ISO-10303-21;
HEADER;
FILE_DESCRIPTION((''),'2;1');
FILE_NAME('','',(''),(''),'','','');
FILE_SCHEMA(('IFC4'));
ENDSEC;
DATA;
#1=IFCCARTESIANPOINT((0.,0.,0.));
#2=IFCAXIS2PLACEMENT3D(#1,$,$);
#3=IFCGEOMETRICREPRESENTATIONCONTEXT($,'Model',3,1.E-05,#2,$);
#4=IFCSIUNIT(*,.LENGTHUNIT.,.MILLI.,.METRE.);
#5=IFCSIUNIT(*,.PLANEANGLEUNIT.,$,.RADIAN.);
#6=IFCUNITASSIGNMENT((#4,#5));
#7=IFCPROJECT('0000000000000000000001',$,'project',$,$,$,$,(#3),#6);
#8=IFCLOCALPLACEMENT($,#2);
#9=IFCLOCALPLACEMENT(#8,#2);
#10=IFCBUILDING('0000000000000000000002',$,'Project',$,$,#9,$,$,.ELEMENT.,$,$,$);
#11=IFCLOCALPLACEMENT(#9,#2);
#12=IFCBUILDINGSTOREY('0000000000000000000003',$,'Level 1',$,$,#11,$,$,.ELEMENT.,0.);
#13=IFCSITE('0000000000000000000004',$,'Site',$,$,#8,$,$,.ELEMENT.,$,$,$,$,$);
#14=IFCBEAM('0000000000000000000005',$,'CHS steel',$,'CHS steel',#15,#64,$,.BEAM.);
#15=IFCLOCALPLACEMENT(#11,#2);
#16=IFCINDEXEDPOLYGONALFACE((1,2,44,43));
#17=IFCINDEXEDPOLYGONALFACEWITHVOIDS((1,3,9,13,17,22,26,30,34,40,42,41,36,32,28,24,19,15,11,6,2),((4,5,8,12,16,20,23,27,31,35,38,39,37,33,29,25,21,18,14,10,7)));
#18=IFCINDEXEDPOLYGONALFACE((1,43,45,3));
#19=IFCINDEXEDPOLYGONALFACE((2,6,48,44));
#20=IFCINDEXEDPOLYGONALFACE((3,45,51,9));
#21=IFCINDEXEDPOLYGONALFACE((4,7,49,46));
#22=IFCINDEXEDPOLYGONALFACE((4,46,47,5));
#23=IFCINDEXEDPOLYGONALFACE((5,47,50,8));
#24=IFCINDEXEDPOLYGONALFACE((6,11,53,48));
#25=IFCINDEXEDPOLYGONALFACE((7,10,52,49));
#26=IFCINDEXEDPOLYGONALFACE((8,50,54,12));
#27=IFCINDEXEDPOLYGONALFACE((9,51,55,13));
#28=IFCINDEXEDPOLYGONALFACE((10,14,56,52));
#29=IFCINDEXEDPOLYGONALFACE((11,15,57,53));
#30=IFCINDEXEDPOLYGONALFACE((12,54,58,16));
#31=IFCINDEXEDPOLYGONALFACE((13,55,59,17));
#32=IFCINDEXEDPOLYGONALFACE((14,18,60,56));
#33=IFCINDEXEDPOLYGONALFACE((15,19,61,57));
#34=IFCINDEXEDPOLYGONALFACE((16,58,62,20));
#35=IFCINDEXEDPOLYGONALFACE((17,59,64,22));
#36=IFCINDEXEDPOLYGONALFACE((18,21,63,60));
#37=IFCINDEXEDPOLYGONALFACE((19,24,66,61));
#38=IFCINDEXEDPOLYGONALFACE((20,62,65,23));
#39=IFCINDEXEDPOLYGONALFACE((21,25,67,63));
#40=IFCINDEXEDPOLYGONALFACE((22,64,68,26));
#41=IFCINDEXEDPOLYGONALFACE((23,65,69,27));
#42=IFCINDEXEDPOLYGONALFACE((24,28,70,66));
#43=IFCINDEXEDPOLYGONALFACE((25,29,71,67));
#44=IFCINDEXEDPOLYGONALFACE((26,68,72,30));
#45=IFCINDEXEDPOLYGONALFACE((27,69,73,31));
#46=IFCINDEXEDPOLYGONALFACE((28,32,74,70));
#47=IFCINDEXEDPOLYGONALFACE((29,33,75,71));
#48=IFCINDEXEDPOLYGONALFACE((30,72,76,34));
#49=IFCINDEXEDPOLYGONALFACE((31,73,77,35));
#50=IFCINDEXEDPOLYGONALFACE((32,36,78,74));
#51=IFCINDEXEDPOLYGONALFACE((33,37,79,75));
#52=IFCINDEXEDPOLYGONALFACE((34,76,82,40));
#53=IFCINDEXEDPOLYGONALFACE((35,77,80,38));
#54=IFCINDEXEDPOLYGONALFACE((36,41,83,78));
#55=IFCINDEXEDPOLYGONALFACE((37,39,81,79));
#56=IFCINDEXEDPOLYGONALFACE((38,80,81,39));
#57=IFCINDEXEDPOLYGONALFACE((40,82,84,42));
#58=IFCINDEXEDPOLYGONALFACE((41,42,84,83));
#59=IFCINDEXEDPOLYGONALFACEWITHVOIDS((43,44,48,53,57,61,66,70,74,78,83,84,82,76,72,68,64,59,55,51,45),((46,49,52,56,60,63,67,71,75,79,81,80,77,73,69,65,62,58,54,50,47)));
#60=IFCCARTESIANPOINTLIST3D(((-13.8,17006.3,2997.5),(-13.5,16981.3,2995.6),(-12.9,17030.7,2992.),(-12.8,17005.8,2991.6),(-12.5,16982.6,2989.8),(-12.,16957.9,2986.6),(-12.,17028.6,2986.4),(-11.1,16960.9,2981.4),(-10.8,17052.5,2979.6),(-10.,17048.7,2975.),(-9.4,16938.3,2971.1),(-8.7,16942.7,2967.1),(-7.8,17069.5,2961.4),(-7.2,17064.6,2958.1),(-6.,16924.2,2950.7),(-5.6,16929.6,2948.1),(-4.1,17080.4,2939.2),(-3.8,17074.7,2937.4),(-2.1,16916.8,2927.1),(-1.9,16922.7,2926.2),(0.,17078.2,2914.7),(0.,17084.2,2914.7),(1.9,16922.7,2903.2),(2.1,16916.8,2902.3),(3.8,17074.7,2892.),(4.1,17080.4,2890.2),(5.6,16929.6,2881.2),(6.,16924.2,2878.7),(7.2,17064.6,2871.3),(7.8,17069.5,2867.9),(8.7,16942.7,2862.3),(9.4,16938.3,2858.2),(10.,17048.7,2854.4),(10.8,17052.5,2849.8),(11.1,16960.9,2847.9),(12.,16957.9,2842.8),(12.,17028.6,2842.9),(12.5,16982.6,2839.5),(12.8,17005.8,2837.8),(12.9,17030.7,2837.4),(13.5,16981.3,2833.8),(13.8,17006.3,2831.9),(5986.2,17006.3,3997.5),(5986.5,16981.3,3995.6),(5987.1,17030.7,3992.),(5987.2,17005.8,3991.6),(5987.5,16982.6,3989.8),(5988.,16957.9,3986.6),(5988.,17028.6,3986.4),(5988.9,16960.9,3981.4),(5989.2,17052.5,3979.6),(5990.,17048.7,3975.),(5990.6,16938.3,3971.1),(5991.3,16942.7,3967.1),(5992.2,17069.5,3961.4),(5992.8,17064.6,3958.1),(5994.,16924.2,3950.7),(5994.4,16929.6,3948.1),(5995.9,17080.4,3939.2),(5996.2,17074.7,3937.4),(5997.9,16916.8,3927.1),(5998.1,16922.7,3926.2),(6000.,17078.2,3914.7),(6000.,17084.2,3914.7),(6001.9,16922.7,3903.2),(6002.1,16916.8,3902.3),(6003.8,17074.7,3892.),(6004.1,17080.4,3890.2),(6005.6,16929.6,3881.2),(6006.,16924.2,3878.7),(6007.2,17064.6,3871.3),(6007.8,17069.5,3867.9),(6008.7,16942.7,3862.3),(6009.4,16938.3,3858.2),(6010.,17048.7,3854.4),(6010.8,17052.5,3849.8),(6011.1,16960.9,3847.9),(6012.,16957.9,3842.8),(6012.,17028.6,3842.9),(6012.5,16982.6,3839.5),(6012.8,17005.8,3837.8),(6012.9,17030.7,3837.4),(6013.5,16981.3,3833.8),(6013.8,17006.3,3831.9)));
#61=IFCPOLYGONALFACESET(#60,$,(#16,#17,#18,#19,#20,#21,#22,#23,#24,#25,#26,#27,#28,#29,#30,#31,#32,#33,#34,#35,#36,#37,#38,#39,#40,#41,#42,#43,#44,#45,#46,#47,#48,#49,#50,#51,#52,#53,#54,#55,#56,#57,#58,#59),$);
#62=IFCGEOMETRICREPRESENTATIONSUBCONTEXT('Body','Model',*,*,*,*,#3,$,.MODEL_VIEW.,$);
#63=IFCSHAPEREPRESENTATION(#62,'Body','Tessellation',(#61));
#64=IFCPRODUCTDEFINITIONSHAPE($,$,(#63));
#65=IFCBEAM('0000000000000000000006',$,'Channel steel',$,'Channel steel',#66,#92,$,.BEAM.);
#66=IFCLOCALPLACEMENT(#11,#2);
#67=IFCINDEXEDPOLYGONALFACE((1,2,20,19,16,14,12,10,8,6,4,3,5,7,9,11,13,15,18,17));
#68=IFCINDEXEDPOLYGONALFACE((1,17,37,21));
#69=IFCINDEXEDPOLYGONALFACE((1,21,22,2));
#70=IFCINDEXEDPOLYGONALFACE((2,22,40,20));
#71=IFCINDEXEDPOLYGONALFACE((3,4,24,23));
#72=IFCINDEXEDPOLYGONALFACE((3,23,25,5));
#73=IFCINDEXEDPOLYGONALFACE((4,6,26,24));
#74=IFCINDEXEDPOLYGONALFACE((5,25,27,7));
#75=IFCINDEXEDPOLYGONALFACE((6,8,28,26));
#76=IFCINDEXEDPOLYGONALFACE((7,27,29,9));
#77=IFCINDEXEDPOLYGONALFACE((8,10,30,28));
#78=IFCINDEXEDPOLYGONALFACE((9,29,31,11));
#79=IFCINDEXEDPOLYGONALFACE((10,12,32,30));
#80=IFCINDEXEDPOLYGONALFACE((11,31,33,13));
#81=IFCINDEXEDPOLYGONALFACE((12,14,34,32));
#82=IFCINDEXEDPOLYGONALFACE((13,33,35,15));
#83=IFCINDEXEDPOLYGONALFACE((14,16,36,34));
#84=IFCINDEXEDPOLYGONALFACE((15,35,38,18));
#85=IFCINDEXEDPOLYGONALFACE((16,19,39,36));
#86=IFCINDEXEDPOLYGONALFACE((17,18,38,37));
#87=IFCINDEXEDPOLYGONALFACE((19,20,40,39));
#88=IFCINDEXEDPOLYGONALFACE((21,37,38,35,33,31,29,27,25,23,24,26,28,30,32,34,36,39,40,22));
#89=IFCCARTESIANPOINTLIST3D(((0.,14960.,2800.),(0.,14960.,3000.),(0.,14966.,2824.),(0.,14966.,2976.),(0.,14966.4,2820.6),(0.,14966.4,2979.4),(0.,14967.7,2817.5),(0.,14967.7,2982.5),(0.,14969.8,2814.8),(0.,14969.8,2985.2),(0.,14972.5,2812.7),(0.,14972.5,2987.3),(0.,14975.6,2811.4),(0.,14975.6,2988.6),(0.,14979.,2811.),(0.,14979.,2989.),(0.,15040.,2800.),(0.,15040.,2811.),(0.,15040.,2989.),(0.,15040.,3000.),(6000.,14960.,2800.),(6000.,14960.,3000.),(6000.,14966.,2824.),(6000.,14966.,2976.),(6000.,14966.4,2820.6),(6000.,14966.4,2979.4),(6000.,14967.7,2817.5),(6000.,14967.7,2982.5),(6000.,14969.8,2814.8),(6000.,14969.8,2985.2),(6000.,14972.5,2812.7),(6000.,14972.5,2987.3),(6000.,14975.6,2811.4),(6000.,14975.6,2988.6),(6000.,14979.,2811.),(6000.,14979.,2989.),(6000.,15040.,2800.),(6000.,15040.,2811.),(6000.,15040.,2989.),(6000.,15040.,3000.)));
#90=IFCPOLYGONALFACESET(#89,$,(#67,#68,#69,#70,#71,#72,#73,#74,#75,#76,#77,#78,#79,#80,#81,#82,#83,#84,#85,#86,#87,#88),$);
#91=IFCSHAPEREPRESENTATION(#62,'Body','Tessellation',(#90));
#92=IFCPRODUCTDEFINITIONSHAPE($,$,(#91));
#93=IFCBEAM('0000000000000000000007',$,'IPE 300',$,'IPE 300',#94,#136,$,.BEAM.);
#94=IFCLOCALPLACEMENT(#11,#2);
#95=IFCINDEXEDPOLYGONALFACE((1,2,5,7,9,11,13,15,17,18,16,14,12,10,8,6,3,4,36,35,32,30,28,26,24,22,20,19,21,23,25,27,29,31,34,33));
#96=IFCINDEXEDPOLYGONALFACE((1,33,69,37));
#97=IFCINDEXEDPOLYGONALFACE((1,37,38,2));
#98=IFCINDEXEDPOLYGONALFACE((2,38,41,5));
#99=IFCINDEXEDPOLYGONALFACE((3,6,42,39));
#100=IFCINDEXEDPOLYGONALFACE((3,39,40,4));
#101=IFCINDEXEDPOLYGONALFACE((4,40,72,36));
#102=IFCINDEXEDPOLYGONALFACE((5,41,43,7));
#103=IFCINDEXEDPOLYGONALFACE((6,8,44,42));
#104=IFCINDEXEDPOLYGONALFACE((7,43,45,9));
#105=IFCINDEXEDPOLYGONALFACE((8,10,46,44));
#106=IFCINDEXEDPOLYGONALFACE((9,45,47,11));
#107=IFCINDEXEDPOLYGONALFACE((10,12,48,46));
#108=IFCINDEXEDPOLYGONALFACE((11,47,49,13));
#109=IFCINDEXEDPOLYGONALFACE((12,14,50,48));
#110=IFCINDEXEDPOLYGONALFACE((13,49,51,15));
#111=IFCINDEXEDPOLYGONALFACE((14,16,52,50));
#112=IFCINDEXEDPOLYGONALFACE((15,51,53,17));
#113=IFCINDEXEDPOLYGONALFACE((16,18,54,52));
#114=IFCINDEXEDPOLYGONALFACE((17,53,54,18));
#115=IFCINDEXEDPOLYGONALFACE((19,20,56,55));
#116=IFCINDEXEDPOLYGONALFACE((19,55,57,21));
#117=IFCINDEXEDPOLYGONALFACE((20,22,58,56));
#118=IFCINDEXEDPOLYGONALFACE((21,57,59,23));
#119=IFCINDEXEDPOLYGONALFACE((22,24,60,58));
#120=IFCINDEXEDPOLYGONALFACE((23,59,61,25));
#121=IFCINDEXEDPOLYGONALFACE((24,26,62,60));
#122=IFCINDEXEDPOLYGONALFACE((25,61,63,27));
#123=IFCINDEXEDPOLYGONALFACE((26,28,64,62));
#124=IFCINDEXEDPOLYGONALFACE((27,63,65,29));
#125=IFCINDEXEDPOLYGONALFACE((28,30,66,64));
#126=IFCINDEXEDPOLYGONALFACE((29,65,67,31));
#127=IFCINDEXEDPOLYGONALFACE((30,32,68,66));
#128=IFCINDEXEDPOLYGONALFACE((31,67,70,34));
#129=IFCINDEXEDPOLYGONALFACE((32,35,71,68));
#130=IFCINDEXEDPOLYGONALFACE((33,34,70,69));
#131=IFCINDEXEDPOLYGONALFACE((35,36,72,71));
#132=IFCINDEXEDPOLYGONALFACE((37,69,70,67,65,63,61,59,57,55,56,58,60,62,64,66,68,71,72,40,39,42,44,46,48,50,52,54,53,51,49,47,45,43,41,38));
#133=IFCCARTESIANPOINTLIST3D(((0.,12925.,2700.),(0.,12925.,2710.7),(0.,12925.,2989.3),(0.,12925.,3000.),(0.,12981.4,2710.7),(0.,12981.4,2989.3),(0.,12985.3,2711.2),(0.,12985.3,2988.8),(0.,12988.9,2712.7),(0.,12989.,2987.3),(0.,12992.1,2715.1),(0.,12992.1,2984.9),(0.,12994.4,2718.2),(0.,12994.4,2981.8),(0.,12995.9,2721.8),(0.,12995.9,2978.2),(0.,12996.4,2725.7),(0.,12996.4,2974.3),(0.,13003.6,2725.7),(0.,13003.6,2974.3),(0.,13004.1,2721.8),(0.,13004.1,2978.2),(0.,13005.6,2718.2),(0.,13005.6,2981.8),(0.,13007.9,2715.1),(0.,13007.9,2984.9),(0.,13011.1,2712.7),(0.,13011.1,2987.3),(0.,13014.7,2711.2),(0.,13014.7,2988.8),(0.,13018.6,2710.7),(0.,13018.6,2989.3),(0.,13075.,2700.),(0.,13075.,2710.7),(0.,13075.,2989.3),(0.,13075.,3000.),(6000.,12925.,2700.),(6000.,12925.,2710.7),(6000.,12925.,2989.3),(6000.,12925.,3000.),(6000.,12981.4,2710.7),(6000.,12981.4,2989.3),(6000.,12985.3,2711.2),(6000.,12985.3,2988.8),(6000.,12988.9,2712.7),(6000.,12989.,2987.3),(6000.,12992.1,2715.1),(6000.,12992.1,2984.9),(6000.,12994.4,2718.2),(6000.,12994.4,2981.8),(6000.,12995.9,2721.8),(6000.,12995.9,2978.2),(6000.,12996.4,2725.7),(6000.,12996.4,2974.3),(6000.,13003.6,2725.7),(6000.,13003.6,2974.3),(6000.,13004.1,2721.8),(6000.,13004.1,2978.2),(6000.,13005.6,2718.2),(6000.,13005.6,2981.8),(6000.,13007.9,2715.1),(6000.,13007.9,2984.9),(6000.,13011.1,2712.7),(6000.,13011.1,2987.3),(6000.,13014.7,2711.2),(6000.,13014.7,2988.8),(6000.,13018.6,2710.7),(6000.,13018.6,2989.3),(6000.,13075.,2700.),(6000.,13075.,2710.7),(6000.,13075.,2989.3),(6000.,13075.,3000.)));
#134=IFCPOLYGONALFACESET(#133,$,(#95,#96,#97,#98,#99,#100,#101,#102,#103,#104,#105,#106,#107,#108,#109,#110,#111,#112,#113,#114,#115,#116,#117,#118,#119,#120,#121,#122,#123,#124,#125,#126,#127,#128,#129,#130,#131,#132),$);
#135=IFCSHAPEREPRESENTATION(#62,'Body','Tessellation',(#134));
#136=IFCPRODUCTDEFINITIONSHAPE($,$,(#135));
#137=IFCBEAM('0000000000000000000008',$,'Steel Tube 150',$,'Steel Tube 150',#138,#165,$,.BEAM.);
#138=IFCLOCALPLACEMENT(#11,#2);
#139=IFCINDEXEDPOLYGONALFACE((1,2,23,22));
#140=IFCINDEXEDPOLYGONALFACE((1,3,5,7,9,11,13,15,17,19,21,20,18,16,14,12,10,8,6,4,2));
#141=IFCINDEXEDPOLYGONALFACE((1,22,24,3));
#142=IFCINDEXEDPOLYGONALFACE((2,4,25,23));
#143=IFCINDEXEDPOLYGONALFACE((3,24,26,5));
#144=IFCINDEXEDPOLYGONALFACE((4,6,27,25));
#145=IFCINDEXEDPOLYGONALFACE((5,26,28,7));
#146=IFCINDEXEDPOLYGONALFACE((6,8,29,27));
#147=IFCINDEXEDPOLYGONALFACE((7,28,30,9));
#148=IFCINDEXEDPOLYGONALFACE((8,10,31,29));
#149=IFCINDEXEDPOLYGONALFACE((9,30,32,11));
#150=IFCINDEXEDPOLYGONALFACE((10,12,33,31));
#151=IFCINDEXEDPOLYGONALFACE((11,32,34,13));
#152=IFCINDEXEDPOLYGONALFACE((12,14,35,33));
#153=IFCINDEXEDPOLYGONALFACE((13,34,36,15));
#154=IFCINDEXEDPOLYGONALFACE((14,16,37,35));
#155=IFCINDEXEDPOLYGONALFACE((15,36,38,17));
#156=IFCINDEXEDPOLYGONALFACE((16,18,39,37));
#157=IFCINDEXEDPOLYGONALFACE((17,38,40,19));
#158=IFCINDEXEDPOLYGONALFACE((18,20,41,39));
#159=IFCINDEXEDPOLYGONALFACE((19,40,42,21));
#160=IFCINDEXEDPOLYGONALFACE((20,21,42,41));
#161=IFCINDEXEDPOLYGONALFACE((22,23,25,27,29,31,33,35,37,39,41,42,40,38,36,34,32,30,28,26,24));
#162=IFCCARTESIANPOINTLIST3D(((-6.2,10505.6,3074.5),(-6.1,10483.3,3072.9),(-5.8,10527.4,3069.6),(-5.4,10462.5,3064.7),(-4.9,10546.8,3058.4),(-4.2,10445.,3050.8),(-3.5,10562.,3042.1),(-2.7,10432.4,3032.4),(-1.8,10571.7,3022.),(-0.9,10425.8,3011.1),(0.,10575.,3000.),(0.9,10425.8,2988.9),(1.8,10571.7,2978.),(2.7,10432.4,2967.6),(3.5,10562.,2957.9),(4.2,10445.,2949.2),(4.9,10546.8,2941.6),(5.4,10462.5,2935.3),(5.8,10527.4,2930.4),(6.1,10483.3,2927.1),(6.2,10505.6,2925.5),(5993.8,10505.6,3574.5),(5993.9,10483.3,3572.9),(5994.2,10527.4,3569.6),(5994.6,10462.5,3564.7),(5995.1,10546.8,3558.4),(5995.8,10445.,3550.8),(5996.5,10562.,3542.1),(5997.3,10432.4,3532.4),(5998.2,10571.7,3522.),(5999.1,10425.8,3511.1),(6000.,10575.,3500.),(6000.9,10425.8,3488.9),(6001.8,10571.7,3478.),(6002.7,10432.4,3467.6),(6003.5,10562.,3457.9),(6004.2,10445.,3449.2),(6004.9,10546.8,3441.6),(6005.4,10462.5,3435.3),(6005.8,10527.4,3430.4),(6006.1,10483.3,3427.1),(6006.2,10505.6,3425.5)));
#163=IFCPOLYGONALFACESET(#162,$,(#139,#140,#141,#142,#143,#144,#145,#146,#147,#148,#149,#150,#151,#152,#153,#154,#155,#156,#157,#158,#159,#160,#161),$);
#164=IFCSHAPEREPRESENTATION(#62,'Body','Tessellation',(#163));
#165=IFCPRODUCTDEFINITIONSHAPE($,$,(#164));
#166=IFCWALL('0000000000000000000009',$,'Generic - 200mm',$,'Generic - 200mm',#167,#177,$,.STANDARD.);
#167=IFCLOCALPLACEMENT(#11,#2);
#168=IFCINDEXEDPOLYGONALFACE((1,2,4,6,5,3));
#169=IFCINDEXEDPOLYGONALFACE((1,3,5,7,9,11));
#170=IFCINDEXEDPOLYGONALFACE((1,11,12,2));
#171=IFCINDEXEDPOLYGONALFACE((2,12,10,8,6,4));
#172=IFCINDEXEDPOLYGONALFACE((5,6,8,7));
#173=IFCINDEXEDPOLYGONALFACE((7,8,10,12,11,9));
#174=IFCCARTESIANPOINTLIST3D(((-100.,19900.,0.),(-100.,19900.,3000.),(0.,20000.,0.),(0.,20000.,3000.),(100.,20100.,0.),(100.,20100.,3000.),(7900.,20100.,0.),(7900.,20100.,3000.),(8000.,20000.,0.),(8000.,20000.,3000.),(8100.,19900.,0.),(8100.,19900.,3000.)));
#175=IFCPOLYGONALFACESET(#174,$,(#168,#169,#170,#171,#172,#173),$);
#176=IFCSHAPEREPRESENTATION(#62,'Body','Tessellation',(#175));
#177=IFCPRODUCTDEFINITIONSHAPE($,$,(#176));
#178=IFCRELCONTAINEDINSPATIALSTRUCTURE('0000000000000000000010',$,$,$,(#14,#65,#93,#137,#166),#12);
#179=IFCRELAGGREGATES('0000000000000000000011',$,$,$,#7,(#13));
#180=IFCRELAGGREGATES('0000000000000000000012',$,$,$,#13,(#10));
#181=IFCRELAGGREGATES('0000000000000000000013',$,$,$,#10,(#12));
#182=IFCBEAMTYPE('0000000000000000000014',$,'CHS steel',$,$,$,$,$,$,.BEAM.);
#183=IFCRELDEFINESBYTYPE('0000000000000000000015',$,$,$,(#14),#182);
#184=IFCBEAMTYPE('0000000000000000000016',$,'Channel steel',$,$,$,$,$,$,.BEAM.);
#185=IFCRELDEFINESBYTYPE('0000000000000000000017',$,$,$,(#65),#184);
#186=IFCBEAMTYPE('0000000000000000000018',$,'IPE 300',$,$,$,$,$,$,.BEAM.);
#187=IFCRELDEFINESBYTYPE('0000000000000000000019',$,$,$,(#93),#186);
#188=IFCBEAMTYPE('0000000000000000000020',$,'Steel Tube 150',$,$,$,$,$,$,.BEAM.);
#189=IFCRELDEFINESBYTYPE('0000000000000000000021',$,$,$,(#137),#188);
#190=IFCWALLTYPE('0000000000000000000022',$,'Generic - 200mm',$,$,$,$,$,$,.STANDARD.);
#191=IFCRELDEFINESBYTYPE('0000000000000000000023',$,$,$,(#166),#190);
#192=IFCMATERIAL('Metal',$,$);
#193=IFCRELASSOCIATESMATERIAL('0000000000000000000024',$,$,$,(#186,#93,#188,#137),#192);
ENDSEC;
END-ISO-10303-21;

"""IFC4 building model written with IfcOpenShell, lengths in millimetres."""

from ifc_helpers import new_model, si_unit, frame, origin, origin_2d, place, context, subcontext, project, spatial, polyline, circle, hollow_circle, i_section, u_section, outline, extrude, material, material_profile, profile_set, profile_usage, type_object, element, save


model = new_model("IFC4")

# Units and contexts
model_context = context("Model", 3, precision=1e-05, world=origin())
body_context = subcontext(model_context, "Body", "Model", "MODEL_VIEW")
ifc_project = project(units=[si_unit("LENGTHUNIT", "METRE", prefix="MILLI"), si_unit("PLANEANGLEUNIT", "RADIAN")], contexts=[model_context])

# Site, building, storey
site_placement = place(None, origin())
site = spatial("IfcSite", under=ifc_project, at=site_placement, Name="Site", CompositionType="ELEMENT")
building_placement = place(site_placement, origin())
building = spatial("IfcBuilding", under=site, at=building_placement, Name="Project", CompositionType="ELEMENT")
storey_placement = place(building_placement, origin())
storey = spatial("IfcBuildingStorey", under=building, at=storey_placement, Name="Level 1", CompositionType="ELEMENT", Elevation=0.0)

# Beams
ifc_material_profile_1 = material_profile(None, hollow_circle(Radius=84.2, WallThickness=6.0, at=origin_2d()), Name="CHS steel")
ifc_profile_set_1 = profile_set([ifc_material_profile_1], Name="CHS steel")
ifc_profile_usage_1 = profile_usage(ifc_profile_set_1, cardinal=8)
beam_type_1 = type_object("IfcBeamType", Name="CHS steel", PredefinedType="BEAM", material=ifc_profile_set_1)
beam_1_placement = place(storey_placement, frame((0.0, 17000.0, 2914.7)))
element("IfcBeam", 1, at=beam_1_placement, inside=storey, type_object=beam_type_1, material=ifc_profile_usage_1, Name="CHS steel", ObjectType="CHS steel", PredefinedType="BEAM", context=body_context, shape_type="SweptSolid", body=[
    extrude(hollow_circle(Radius=84.2, WallThickness=6.0, at=origin_2d()), frame((0.0, 0.0, 0.0), z_axis=(0.986394, 0.0, 0.164399), x_axis=(0.0, 1.0, 0.0)), (0.0, 0.0, 1.0), 6082.8),
])
ifc_material_profile_2 = material_profile(None, u_section(Depth=200.0, FlangeWidth=80.0, WebThickness=6.0, FlangeThickness=11.0, FilletRadius=13.0, at=origin_2d()), Name="Channel steel")
ifc_profile_set_2 = profile_set([ifc_material_profile_2], Name="Channel steel")
ifc_profile_usage_2 = profile_usage(ifc_profile_set_2, cardinal=8)
beam_type_2 = type_object("IfcBeamType", Name="Channel steel", PredefinedType="BEAM", material=ifc_profile_set_2)
beam_2_placement = place(storey_placement, frame((0.0, 15000.0, 2900.0)))
element("IfcBeam", 2, at=beam_2_placement, inside=storey, type_object=beam_type_2, material=ifc_profile_usage_2, Name="Channel steel", ObjectType="Channel steel", PredefinedType="BEAM", context=body_context, shape_type="SweptSolid", body=[
    extrude(u_section(Depth=200.0, FlangeWidth=80.0, WebThickness=6.0, FlangeThickness=11.0, FilletRadius=13.0, at=origin_2d()), frame((0.0, 0.0, 0.0), z_axis=(1.0, 0.0, 0.0), x_axis=(0.0, 1.0, 0.0)), (0.0, 0.0, 1.0), 6000.0),
])
ifc_material_1 = material(Name="Metal")
ifc_material_profile_3 = material_profile(ifc_material_1, i_section(OverallWidth=150.0, OverallDepth=300.0, WebThickness=7.1, FlangeThickness=10.7, FilletRadius=15.0, at=origin_2d()), Name="IPE 300")
ifc_profile_set_3 = profile_set([ifc_material_profile_3], Name="IPE 300")
ifc_profile_usage_3 = profile_usage(ifc_profile_set_3, cardinal=8)
beam_type_3 = type_object("IfcBeamType", Name="IPE 300", PredefinedType="BEAM", material=ifc_profile_set_3)
beam_3_placement = place(storey_placement, frame((0.0, 13000.0, 2850.0)))
element("IfcBeam", 3, at=beam_3_placement, inside=storey, type_object=beam_type_3, material=ifc_profile_usage_3, Name="IPE 300", ObjectType="IPE 300", PredefinedType="BEAM", context=body_context, shape_type="SweptSolid", body=[
    extrude(i_section(OverallWidth=150.0, OverallDepth=300.0, WebThickness=7.1, FlangeThickness=10.7, FilletRadius=15.0, at=origin_2d()), frame((0.0, 0.0, 0.0), z_axis=(1.0, 0.0, 0.0), x_axis=(0.0, 1.0, 0.0)), (0.0, 0.0, 1.0), 6000.0),
])
ifc_material_profile_4 = material_profile(ifc_material_1, circle(Radius=75.0, at=origin_2d()), Name="Steel Tube 150")
ifc_profile_set_4 = profile_set([ifc_material_profile_4], Name="Steel Tube 150")
ifc_profile_usage_4 = profile_usage(ifc_profile_set_4, cardinal=5)
beam_type_4 = type_object("IfcBeamType", Name="Steel Tube 150", PredefinedType="BEAM", material=ifc_profile_set_4)
beam_4_placement = place(storey_placement, frame((0.0, 10500.0, 3000.0)))
element("IfcBeam", 4, at=beam_4_placement, inside=storey, type_object=beam_type_4, material=ifc_profile_usage_4, Name="Steel Tube 150", ObjectType="Steel Tube 150", PredefinedType="BEAM", context=body_context, shape_type="SweptSolid", body=[
    extrude(circle(Radius=75.0, at=origin_2d()), frame((0.0, 0.0, 0.0), z_axis=(0.996546, 0.0, 0.083045), x_axis=(0.0, 1.0, 0.0)), (0.0, 0.0, 1.0), 6020.8),
])

# Wall
wall_type = type_object("IfcWallType", Name="Generic - 200mm", PredefinedType="STANDARD")
wall_1_placement = place(storey_placement, frame((0.0, 20000.0, 0.0), z_axis=(0.0, 0.0, 1.0), x_axis=(1.0, 0.0, 0.0)))
element("IfcWall", 5, at=wall_1_placement, inside=storey, type_object=wall_type, Name="Generic - 200mm", ObjectType="Generic - 200mm", PredefinedType="STANDARD", context=body_context, shape_type="SweptSolid", body=[
    extrude(outline(polyline([(-100.0, -100.0), (0.0, 0.0), (100.0, 100.0), (7900.0, 100.0), (8000.0, 0.0), (8100.0, -100.0), (-100.0, -100.0)])), origin(), (0.0, 0.0, 1.0), 3000.0),
])

save(model, "model.ifc")
